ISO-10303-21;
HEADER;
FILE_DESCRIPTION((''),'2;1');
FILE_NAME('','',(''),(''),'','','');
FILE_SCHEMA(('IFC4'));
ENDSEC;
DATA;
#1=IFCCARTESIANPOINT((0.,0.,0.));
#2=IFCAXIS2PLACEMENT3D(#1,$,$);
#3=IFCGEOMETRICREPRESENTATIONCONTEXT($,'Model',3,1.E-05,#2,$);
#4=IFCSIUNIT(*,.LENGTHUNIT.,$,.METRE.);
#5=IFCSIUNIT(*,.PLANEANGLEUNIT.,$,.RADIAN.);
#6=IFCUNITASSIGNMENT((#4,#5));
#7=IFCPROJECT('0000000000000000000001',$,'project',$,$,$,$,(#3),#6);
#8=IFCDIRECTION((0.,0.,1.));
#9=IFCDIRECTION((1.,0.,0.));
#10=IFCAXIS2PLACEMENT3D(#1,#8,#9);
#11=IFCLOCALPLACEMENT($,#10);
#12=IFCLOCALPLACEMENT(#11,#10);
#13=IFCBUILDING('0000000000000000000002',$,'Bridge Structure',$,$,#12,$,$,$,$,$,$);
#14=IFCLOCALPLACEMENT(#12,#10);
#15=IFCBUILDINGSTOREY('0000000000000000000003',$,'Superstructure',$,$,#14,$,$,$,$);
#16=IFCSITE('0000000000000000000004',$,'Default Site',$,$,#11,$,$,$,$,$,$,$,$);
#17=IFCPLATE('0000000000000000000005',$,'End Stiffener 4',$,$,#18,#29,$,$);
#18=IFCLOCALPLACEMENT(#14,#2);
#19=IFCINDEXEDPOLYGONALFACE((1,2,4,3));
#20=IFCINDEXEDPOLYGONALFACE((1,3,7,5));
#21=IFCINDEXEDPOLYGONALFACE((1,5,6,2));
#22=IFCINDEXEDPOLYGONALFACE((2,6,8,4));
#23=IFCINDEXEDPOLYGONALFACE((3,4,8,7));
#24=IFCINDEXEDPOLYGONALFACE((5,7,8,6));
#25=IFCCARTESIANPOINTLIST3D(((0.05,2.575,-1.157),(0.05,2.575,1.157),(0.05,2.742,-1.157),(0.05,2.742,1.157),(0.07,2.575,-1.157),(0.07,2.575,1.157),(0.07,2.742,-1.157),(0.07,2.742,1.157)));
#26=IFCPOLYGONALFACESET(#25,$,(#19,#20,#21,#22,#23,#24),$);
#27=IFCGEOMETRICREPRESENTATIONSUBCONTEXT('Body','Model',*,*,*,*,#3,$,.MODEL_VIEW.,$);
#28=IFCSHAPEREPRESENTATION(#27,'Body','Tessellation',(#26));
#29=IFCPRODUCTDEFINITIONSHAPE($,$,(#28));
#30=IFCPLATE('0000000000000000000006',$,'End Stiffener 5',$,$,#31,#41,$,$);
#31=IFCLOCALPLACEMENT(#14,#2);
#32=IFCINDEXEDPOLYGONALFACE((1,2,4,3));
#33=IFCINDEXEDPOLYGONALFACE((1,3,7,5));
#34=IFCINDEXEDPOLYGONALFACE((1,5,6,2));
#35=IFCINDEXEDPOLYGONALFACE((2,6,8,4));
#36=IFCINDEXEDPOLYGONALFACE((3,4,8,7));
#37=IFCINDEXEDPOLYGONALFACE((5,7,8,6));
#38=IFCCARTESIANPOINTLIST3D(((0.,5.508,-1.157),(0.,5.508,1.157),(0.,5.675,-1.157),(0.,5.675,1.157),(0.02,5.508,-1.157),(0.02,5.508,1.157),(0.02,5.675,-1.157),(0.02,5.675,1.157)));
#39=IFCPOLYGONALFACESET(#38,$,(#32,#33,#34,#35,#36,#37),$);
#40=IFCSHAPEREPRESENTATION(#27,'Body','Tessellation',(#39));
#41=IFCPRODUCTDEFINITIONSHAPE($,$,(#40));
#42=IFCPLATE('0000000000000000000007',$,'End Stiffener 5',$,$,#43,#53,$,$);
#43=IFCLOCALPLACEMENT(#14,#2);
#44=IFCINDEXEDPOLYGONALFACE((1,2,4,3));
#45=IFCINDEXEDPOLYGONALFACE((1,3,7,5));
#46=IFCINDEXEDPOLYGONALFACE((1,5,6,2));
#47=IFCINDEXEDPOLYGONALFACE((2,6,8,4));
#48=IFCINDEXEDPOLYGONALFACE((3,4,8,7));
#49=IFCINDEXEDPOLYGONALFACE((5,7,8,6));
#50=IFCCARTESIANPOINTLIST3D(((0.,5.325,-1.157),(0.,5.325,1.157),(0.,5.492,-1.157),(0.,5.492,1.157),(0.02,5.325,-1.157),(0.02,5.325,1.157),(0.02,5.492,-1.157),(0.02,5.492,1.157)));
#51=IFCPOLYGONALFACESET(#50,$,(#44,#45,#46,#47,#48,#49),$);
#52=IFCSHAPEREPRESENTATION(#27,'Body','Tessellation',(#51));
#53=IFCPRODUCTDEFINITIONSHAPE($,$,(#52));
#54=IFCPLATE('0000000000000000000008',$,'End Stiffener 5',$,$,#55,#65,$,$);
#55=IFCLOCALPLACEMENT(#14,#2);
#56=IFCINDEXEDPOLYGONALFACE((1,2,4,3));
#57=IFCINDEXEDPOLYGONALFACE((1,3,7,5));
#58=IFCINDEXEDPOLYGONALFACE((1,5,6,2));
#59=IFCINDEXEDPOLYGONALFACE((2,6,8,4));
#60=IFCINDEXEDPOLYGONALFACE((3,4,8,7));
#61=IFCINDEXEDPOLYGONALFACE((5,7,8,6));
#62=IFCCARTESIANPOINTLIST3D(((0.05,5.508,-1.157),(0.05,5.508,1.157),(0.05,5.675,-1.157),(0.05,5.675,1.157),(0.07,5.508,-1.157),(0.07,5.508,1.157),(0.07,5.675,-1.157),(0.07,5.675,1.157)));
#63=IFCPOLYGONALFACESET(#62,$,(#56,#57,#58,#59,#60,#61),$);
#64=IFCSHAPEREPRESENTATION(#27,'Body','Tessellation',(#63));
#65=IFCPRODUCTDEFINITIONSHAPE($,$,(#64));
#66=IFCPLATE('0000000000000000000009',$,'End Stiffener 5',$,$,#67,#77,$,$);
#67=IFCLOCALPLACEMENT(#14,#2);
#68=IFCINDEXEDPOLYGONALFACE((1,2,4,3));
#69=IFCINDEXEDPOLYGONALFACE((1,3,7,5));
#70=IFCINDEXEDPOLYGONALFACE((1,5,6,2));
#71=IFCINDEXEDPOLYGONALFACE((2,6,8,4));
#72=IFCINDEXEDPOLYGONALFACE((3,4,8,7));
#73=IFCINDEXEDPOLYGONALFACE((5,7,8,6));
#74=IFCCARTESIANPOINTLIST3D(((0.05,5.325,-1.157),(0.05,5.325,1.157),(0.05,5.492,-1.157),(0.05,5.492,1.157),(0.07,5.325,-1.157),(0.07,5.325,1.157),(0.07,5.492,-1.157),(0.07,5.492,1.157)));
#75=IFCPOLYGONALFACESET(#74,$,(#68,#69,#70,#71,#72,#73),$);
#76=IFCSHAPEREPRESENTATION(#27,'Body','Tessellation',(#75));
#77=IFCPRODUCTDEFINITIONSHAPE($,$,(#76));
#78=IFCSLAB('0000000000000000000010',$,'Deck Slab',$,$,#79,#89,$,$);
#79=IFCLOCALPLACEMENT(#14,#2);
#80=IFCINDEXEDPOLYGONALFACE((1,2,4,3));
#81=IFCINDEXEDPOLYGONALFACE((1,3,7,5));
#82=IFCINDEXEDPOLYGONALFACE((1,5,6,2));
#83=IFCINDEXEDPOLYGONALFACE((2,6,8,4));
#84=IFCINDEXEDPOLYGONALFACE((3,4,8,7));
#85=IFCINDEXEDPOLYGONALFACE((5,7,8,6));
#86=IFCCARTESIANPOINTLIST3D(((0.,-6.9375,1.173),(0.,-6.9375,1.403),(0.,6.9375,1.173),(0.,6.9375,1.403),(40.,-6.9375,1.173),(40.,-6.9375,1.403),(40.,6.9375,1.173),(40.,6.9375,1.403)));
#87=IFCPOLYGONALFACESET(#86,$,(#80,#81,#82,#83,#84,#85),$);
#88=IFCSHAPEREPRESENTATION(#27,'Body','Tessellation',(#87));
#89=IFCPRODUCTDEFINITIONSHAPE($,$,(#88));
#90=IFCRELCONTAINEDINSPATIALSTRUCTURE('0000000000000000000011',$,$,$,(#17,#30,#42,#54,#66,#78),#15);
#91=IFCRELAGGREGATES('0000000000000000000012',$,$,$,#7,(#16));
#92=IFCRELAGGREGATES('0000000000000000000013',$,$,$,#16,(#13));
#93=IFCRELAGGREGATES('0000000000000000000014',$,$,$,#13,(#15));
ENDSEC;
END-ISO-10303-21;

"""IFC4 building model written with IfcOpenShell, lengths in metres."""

from ifc_helpers import new_model, si_unit, frame, origin, origin_with_axes, origin_2d_with_axis, place, context, subcontext, project, spatial, polyline, rectangle, outline, extrude, element, save


model = new_model("IFC4")

# Units and contexts
model_context = context("Model", 3, precision=1e-05, world=origin())
body_context = subcontext(model_context, "Body", "Model", "MODEL_VIEW")
ifc_project = project(units=[si_unit("LENGTHUNIT", "METRE"), si_unit("PLANEANGLEUNIT", "RADIAN")], contexts=[model_context])

# Site, building, storey
site_placement = place(None, origin_with_axes())
site = spatial("IfcSite", under=ifc_project, at=site_placement, Name="Default Site")
building_placement = place(site_placement, origin_with_axes())
building = spatial("IfcBuilding", under=site, at=building_placement, Name="Bridge Structure")
storey_placement = place(building_placement, origin_with_axes())
storey = spatial("IfcBuildingStorey", under=building, at=storey_placement, Name="Superstructure")

# Plates
for number, where, z_axis, x_axis, name in (
    (1, (0.06, 2.6585, -1.157), (0.0, 0.0, 1.0), (1.0, 0.0, 0.0), "End Stiffener 4"),
    (2, (0.01, 5.5915, -1.157), (0.0, 0.0, 1.0), (1.0, 0.0, 0.0), "End Stiffener 5"),
    (3, (0.01, 5.4085, -1.157), (0.0, 0.0, 1.0), (1.0, 0.0, 0.0), "End Stiffener 5"),
    (4, (0.06, 5.5915, -1.157), (0.0, 0.0, 1.0), (1.0, 0.0, 0.0), "End Stiffener 5"),
    (5, (0.06, 5.4085, -1.157), (0.0, 0.0, 1.0), (1.0, 0.0, 0.0), "End Stiffener 5"),
):
    element("IfcPlate", number, at=place(storey_placement, frame(where, z_axis=z_axis, x_axis=x_axis)), inside=storey, Name=name, context=body_context, shape_type="SweptSolid", body=[
        extrude(rectangle(XDim=0.02, YDim=0.167, at=origin_2d_with_axis()), origin_with_axes(), (0.0, 0.0, 1.0), 2.314),
    ])

# Slab
slab_placement = place(storey_placement, frame((0.0, 0.0, 1.173), z_axis=(0.0, 0.0, 1.0), x_axis=(1.0, 0.0, 0.0)))
element("IfcSlab", 6, at=slab_placement, inside=storey, Name="Deck Slab", context=body_context, shape_type="SweptSolid", body=[
    extrude(outline(polyline([(0.0, -6.9375), (40.0, -6.9375), (40.0, 6.9375), (0.0, 6.9375), (0.0, -6.9375)])), origin_with_axes(), (0.0, 0.0, 1.0), 0.23),
])

save(model, "model.ifc")
